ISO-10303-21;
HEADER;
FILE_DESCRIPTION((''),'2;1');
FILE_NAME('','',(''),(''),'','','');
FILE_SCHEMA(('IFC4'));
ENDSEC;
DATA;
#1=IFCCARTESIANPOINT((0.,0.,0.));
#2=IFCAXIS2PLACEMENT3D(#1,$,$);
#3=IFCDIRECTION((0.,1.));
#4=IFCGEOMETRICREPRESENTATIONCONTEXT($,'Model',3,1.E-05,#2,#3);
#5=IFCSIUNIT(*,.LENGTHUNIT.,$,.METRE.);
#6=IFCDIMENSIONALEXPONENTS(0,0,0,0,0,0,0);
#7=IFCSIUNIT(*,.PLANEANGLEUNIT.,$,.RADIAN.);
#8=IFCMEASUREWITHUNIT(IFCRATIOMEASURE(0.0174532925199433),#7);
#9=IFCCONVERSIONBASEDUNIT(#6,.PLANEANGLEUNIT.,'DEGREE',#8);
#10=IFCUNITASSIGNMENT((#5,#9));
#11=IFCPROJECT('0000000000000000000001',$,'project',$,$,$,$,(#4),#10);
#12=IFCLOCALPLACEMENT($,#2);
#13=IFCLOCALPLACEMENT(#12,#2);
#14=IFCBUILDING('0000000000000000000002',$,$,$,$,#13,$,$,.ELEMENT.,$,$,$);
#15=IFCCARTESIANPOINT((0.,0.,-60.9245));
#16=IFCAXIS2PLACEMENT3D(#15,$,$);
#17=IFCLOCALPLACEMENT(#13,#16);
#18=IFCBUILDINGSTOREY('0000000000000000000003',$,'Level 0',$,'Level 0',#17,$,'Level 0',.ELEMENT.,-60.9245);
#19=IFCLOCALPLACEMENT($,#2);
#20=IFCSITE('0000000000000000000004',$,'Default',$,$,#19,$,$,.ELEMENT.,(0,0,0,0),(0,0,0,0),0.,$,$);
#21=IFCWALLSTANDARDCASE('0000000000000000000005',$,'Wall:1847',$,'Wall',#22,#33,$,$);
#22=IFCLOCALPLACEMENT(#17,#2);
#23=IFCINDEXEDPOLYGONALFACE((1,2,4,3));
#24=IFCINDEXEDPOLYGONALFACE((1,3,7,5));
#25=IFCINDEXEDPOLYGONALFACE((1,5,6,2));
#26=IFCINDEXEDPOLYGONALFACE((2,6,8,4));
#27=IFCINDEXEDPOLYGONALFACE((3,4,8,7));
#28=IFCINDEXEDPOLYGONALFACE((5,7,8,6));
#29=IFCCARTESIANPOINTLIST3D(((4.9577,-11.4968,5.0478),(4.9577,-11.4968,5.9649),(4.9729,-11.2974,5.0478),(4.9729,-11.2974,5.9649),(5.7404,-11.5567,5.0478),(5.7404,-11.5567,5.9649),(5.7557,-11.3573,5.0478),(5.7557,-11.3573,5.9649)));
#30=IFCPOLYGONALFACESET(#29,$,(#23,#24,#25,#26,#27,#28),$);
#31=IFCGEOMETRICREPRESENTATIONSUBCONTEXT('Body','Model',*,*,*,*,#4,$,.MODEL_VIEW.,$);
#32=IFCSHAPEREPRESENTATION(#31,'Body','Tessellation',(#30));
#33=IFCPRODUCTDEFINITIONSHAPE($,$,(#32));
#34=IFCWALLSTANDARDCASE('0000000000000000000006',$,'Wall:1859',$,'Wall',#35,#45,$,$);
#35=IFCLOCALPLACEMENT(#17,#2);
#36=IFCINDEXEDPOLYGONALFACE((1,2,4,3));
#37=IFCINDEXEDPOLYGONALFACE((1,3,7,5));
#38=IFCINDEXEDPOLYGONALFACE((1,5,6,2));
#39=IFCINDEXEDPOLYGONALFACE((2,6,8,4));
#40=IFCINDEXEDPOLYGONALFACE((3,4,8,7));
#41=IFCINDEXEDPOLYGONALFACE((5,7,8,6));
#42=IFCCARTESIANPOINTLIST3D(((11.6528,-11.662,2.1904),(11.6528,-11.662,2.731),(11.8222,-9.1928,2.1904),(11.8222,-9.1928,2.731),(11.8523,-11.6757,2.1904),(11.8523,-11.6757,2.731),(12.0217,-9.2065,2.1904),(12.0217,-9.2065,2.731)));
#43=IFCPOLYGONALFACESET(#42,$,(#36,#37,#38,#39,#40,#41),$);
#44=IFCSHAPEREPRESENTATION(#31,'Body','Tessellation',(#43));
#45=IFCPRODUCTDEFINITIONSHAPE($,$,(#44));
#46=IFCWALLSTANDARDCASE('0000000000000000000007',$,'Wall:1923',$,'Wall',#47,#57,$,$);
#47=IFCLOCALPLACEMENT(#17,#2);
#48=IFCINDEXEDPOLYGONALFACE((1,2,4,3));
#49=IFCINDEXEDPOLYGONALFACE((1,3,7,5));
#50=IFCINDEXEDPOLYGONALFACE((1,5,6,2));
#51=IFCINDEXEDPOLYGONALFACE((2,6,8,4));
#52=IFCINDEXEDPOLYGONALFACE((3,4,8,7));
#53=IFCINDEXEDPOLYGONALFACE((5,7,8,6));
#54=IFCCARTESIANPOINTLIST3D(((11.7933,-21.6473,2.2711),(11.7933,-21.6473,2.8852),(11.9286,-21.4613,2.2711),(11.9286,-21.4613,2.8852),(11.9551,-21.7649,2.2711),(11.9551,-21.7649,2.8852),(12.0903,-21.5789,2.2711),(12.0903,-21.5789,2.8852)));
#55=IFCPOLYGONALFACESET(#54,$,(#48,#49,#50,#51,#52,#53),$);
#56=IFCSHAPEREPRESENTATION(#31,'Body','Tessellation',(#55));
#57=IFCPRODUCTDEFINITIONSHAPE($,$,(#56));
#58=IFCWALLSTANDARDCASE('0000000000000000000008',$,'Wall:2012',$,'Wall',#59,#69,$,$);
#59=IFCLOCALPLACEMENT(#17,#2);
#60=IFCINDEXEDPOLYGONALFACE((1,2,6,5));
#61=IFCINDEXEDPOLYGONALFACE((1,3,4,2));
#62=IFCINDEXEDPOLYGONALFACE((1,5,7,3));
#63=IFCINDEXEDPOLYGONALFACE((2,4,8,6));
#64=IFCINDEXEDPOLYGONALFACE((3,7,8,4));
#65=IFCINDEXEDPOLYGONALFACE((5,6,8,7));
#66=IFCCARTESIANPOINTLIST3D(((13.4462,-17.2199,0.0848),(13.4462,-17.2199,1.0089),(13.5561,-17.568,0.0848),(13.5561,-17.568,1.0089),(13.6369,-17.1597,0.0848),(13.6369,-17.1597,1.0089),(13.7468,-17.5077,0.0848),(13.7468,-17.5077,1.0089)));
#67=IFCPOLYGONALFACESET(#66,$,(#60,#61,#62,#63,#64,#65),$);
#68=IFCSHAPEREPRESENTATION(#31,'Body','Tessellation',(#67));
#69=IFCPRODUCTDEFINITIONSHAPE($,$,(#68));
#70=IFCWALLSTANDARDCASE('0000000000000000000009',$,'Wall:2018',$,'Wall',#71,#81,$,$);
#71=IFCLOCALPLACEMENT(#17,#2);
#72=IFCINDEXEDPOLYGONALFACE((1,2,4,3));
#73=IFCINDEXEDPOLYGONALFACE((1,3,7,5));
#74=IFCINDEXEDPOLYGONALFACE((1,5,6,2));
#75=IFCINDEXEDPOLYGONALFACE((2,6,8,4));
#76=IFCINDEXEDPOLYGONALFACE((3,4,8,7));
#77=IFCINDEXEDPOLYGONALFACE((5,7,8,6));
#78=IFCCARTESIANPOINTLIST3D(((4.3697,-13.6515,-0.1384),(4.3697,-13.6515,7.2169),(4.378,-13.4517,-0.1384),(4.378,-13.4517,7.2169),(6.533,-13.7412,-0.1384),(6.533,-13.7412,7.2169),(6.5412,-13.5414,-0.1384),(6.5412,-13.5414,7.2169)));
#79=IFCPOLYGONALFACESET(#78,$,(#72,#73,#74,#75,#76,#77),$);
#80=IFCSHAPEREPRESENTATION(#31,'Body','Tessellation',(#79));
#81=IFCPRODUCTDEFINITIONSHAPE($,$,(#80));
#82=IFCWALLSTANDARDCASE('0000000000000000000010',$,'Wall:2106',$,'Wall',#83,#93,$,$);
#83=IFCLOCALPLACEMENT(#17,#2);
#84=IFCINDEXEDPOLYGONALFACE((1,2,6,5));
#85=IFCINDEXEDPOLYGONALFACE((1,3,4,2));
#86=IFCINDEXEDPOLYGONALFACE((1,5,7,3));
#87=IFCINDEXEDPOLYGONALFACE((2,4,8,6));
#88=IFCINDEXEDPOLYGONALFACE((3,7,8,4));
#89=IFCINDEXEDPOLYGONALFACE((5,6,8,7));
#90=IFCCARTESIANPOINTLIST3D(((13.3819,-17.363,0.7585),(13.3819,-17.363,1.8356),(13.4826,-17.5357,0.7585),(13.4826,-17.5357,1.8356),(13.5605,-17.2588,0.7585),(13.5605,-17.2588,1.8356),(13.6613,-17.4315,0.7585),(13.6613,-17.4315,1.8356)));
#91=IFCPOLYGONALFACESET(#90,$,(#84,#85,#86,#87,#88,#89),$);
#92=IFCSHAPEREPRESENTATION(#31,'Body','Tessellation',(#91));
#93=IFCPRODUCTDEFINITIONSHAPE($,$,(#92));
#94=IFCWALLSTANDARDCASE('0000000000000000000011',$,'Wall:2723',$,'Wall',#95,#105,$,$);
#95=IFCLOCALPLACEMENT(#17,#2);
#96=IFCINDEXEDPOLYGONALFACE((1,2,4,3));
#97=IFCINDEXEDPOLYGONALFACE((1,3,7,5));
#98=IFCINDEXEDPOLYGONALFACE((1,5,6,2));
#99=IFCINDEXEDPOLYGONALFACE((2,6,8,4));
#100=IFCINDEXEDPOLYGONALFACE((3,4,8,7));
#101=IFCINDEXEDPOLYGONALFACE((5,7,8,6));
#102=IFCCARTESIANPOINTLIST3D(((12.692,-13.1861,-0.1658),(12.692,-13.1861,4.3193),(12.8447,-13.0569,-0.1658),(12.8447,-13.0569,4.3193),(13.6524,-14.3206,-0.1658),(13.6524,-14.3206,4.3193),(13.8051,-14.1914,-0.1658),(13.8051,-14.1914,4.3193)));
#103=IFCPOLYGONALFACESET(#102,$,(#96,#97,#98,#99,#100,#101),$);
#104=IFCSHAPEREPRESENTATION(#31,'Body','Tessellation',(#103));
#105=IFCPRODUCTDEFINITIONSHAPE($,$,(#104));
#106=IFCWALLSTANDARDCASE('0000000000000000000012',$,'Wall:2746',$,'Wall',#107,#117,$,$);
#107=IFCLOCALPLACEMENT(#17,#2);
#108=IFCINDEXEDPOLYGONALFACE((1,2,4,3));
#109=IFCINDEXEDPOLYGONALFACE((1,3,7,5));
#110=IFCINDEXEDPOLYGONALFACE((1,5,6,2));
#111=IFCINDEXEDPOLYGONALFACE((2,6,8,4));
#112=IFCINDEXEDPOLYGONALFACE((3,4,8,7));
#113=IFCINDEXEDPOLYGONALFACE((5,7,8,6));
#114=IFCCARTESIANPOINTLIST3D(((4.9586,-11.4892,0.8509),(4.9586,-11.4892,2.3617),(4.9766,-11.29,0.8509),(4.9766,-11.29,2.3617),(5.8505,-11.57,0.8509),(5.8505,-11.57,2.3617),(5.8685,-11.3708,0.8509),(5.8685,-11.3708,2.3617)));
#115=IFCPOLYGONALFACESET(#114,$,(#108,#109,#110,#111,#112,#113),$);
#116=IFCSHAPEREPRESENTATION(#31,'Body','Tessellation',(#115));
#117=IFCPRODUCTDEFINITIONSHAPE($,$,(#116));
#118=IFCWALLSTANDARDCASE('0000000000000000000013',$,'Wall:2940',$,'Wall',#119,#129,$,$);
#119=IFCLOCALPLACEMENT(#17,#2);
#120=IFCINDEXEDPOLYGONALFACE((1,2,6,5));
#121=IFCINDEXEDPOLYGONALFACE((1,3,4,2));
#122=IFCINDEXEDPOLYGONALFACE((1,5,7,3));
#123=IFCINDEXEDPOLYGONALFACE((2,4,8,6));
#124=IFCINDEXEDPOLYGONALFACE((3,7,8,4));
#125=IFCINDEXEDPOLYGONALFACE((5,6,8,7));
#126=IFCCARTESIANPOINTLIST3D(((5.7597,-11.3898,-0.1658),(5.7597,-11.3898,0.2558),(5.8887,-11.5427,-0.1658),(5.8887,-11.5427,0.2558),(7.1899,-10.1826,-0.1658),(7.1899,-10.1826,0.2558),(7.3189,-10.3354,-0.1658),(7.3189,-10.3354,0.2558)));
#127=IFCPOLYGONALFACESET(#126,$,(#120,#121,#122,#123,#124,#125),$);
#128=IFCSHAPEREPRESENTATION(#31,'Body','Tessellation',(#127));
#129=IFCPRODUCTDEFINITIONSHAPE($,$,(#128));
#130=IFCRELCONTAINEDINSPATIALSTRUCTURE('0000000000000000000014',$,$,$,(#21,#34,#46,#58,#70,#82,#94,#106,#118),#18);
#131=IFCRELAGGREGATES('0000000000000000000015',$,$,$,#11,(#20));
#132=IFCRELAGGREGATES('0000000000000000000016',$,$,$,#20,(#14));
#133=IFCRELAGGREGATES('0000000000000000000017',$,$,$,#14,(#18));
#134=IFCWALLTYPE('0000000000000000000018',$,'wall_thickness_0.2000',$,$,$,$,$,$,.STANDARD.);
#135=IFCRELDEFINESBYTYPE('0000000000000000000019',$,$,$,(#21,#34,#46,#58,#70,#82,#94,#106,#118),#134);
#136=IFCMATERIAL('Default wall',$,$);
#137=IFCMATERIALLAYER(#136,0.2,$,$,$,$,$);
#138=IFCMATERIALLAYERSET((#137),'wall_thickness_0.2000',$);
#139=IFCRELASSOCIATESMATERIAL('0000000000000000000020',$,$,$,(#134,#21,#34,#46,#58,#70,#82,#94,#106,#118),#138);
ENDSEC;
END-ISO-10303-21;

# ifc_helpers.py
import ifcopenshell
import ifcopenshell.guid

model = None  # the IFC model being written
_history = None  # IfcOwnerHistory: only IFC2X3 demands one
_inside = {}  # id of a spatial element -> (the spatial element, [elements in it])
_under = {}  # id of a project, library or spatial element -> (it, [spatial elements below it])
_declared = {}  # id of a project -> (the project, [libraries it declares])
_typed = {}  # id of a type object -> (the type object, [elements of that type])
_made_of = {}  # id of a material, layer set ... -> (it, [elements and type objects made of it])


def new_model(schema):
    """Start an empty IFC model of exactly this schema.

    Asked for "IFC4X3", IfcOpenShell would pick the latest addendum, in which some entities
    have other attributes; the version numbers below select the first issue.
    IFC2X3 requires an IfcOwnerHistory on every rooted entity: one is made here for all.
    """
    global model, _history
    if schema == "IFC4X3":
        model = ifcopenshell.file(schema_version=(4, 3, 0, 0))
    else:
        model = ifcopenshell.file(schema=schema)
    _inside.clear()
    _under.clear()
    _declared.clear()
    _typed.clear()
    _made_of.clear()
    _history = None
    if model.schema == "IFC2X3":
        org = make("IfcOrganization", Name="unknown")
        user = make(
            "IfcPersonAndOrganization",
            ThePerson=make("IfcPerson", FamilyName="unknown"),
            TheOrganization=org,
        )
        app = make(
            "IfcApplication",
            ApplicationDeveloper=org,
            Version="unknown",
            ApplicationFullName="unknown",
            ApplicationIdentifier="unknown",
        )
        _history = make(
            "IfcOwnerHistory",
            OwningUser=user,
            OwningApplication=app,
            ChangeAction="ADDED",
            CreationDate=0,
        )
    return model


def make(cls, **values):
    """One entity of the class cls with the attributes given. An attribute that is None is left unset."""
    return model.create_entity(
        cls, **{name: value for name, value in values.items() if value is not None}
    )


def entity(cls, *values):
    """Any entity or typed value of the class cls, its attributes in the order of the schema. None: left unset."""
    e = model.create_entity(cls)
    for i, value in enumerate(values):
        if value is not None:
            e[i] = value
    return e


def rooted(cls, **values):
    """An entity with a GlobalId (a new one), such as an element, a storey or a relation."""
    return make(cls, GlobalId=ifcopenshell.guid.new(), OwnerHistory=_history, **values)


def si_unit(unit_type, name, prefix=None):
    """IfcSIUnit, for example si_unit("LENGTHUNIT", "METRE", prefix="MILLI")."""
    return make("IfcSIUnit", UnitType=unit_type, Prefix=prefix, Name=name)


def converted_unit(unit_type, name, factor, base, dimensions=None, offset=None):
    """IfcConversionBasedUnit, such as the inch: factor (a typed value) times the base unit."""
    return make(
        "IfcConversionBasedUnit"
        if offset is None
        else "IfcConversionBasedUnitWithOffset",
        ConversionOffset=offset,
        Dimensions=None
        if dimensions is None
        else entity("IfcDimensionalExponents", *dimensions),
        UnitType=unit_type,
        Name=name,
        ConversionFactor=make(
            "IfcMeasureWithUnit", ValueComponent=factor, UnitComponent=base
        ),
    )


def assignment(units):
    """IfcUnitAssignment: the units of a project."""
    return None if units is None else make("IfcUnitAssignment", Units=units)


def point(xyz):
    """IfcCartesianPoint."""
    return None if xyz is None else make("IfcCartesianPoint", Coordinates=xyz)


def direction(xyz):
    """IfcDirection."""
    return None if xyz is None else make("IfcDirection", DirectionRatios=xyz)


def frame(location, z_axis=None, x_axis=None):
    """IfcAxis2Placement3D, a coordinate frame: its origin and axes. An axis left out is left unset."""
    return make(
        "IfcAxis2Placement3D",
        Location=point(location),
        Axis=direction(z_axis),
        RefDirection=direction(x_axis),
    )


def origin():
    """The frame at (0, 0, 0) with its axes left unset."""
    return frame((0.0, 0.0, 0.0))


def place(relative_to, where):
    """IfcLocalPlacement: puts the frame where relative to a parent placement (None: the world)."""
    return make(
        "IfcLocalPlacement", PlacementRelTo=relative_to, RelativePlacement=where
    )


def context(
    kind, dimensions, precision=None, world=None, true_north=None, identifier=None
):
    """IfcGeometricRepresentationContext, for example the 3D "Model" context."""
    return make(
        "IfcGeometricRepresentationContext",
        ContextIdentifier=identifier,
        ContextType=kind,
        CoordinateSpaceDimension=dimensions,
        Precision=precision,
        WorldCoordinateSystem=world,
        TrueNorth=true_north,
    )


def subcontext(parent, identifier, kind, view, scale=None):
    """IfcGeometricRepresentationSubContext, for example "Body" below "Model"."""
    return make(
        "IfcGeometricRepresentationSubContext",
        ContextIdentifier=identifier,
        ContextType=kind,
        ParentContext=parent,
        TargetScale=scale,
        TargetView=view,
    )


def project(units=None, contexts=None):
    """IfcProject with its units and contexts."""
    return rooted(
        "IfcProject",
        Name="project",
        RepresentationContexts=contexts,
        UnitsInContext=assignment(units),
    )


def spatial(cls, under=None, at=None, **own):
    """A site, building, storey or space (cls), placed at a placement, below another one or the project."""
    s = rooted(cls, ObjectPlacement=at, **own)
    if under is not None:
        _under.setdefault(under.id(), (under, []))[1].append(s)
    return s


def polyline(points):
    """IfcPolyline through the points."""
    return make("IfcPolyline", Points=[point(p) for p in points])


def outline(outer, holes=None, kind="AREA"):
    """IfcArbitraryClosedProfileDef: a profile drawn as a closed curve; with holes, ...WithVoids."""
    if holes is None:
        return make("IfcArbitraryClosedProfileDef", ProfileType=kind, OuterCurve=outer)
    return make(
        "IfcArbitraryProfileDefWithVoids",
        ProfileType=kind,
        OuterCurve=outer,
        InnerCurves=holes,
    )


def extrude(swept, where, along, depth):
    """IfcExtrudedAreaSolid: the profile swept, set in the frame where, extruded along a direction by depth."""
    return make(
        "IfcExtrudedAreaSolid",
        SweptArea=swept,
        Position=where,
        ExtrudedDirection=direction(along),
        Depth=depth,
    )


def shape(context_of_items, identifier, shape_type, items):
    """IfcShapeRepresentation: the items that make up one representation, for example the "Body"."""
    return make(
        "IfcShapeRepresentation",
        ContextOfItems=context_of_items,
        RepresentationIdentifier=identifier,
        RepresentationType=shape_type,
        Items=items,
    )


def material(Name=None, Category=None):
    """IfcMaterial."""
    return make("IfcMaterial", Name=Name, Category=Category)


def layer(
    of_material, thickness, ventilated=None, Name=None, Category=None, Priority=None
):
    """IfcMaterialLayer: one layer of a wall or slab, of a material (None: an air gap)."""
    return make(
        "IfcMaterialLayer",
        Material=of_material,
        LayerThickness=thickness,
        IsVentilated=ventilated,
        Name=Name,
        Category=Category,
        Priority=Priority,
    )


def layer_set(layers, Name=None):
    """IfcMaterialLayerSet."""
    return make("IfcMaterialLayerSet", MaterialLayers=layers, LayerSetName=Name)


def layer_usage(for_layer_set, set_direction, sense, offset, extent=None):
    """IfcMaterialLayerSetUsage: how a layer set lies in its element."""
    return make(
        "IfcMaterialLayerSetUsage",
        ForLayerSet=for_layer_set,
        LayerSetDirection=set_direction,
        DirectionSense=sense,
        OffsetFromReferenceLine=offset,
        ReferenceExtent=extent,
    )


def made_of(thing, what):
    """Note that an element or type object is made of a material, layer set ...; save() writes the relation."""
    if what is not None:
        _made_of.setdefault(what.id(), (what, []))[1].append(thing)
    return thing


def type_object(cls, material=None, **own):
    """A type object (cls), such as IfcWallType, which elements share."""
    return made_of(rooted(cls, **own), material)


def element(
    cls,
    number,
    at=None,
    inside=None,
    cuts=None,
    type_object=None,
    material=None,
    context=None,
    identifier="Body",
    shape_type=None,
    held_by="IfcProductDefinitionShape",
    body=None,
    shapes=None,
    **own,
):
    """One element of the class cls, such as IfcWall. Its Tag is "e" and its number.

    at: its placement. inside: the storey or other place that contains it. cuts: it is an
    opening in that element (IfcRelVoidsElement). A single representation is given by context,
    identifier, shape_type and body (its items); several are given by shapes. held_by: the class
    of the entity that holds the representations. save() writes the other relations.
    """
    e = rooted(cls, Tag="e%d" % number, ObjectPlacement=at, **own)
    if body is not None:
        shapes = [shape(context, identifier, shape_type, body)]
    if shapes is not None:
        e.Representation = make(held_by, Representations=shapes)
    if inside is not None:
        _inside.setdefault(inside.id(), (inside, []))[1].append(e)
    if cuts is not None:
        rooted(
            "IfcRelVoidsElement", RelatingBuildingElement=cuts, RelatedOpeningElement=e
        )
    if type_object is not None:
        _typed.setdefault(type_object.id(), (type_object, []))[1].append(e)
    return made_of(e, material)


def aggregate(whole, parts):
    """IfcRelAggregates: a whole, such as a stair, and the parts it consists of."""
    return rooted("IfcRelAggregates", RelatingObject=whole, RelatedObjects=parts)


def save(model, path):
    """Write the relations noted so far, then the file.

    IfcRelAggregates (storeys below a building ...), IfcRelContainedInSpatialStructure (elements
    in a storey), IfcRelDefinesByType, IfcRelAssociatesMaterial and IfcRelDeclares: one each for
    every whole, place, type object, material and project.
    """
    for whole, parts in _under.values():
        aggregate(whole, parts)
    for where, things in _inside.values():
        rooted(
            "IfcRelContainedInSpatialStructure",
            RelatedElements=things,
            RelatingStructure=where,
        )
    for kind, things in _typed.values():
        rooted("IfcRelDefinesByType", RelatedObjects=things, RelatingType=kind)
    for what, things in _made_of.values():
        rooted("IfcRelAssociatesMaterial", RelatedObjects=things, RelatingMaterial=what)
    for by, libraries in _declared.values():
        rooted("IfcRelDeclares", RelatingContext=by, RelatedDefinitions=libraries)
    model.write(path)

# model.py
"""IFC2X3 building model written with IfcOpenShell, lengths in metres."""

from ifc_helpers import new_model, entity, si_unit, converted_unit, direction, frame, origin, place, context, subcontext, project, spatial, polyline, outline, extrude, material, layer, layer_set, layer_usage, type_object, element, save


model = new_model("IFC2X3")

# Units and contexts
model_context = context("Model", 3, precision=1e-05, world=origin(), true_north=direction((0.0, 1.0)))
body_context = subcontext(model_context, "Body", "Model", "MODEL_VIEW")
ifc_project = project(units=[si_unit("LENGTHUNIT", "METRE"), converted_unit("PLANEANGLEUNIT", "DEGREE", entity("IfcRatioMeasure", 0.0174532925199433), si_unit("PLANEANGLEUNIT", "RADIAN"), dimensions=[0, 0, 0, 0, 0, 0, 0])], contexts=[model_context])

# Site, building, storey
site_placement = place(None, origin())
site = spatial("IfcSite", under=ifc_project, at=site_placement, Name="Default", CompositionType="ELEMENT", RefLatitude=(0, 0, 0, 0), RefLongitude=(0, 0, 0, 0), RefElevation=0.0)
placement_1 = place(None, origin())
building_placement = place(placement_1, origin())
building = spatial("IfcBuilding", under=site, at=building_placement, CompositionType="ELEMENT")
storey_placement = place(building_placement, frame((0.0, 0.0, -60.9245)))
storey = spatial("IfcBuildingStorey", under=building, at=storey_placement, Name="Level 0", ObjectType="Level 0", LongName="Level 0", CompositionType="ELEMENT", Elevation=-60.9245)

# Shared definitions
ifc_material_1 = material(Name="Default wall")
ifc_layer = layer(ifc_material_1, 0.2)
ifc_layer_set = layer_set([ifc_layer], Name="wall_thickness_0.2000")
ifc_layer_usage = layer_usage(ifc_layer_set, "AXIS2", "POSITIVE", -0.1)
wall_type = type_object("IfcWallType", Name="wall_thickness_0.2000", PredefinedType="STANDARD", material=ifc_layer_set)

# Walls
placement_2 = place(building_placement, frame((0.0, 0.0, -55.8767)))
wall_1_placement = place(placement_2, frame((5.748, -11.457, 0.0), z_axis=(0.0, 0.0, 1.0), x_axis=(-0.997084, 0.076317, 0.0)))
element("IfcWallStandardCase", 1, at=wall_1_placement, inside=storey, type_object=wall_type, material=ifc_layer_usage, Name="Wall:1847", ObjectType="Wall", context=body_context, shape_type="SweptSolid", body=[
    extrude(outline(polyline([(0.785, -0.1), (0.785, 0.1), (0.0, 0.1), (0.0, -0.1), (0.785, -0.1)])), origin(), (0.0, 0.0, 1.0), 0.9171),
])
placement_3 = place(building_placement, frame((0.0, 0.0, -58.7341)))
wall_2_placement = place(placement_3, frame((11.7525, -11.6688, 0.0), z_axis=(0.0, 0.0, 1.0), x_axis=(0.068442, 0.997655, 0.0)))
element("IfcWallStandardCase", 2, at=wall_2_placement, inside=storey, type_object=wall_type, material=ifc_layer_usage, Name="Wall:1859", ObjectType="Wall", context=body_context, shape_type="SweptSolid", body=[
    extrude(outline(polyline([(2.475, -0.1), (2.475, 0.1), (0.0, 0.1), (0.0, -0.1), (2.475, -0.1)])), origin(), (0.0, 0.0, 1.0), 0.5407),
])
placement_4 = place(building_placement, frame((0.0, 0.0, -58.6534)))
wall_3_placement = place(placement_4, frame((12.0095, -21.5201, 0.0), z_axis=(0.0, 0.0, 1.0), x_axis=(-0.588006, -0.808856, 0.0)))
element("IfcWallStandardCase", 3, at=wall_3_placement, inside=storey, type_object=wall_type, material=ifc_layer_usage, Name="Wall:1923", ObjectType="Wall", context=body_context, shape_type="SweptSolid", body=[
    extrude(outline(polyline([(0.23, -0.1), (0.23, 0.1), (0.0, 0.1), (0.0, -0.1), (0.23, -0.1)])), origin(), (0.0, 0.0, 1.0), 0.6141),
])
placement_5 = place(building_placement, frame((0.0, 0.0, -60.8397)))
wall_4_placement = place(placement_5, frame((13.6514, -17.5378, 0.0), z_axis=(0.0, 0.0, 1.0), x_axis=(-0.301101, 0.953592, 0.0)))
element("IfcWallStandardCase", 4, at=wall_4_placement, inside=storey, type_object=wall_type, material=ifc_layer_usage, Name="Wall:2012", ObjectType="Wall", context=body_context, shape_type="SweptSolid", body=[
    extrude(outline(polyline([(0.365, -0.1), (0.365, 0.1), (0.0, 0.1), (0.0, -0.1), (0.365, -0.1)])), origin(), (0.0, 0.0, 1.0), 0.9242),
])
placement_6 = place(building_placement, frame((0.0, 0.0, -61.0629)))
wall_5_placement = place(placement_6, frame((6.5371, -13.6413, 0.0), z_axis=(0.0, 0.0, 1.0), x_axis=(-0.999142, 0.041423, 0.0)))
element("IfcWallStandardCase", 5, at=wall_5_placement, inside=storey, type_object=wall_type, material=ifc_layer_usage, Name="Wall:2018", ObjectType="Wall", context=body_context, shape_type="SweptSolid", body=[
    extrude(outline(polyline([(2.1651, -0.1), (2.1651, 0.1), (0.0, 0.1), (0.0, -0.1), (2.1651, -0.1)])), origin(), (0.0, 0.0, 1.0), 7.3553),
])
placement_7 = place(building_placement, frame((0.0, 0.0, -60.166)))
wall_6_placement = place(placement_7, frame((13.6109, -17.3451, 0.0), z_axis=(0.0, 0.0, 1.0), x_axis=(-0.863775, -0.503878, 0.0)))
element("IfcWallStandardCase", 6, at=wall_6_placement, inside=storey, type_object=wall_type, material=ifc_layer_usage, Name="Wall:2106", ObjectType="Wall", context=body_context, shape_type="SweptSolid", body=[
    extrude(outline(polyline([(0.2068, -0.1), (0.2068, 0.1), (0.0, 0.1), (0.0, -0.1), (0.2068, -0.1)])), origin(), (0.0, 0.0, 1.0), 1.0771),
])
placement_8 = place(building_placement, frame((0.0, 0.0, -61.0903)))
wall_7_placement = place(placement_8, frame((13.7287, -14.256, 0.0), z_axis=(0.0, 0.0, 1.0), x_axis=(-0.646115, 0.76324, 0.0)))
element("IfcWallStandardCase", 7, at=wall_7_placement, inside=storey, type_object=wall_type, material=ifc_layer_usage, Name="Wall:2723", ObjectType="Wall", context=body_context, shape_type="SweptSolid", body=[
    extrude(outline(polyline([(1.4864, -0.1), (1.4864, 0.1), (0.0, 0.1), (0.0, -0.1), (1.4864, -0.1)])), origin(), (0.0, 0.0, 1.0), 4.4851),
])
placement_9 = place(building_placement, frame((0.0, 0.0, -60.0736)))
wall_8_placement = place(placement_9, frame((4.9676, -11.3896, 0.0), z_axis=(0.0, 0.0, 1.0), x_axis=(0.995925, -0.090187, 0.0)))
element("IfcWallStandardCase", 8, at=wall_8_placement, inside=storey, type_object=wall_type, material=ifc_layer_usage, Name="Wall:2746", ObjectType="Wall", context=body_context, shape_type="SweptSolid", body=[
    extrude(outline(polyline([(0.8956, -0.1), (0.8956, 0.1), (0.0, 0.1), (0.0, -0.1), (0.8956, -0.1)])), origin(), (0.0, 0.0, 1.0), 1.5109),
])
placement_10 = place(building_placement, frame((0.0, 0.0, -61.0903)))
wall_9_placement = place(placement_10, frame((5.8242, -11.4663, 0.0), z_axis=(0.0, 0.0, 1.0), x_axis=(0.764167, 0.645019, 0.0)))
element("IfcWallStandardCase", 9, at=wall_9_placement, inside=storey, type_object=wall_type, material=ifc_layer_usage, Name="Wall:2940", ObjectType="Wall", context=body_context, shape_type="SweptSolid", body=[
    extrude(outline(polyline([(1.8716, -0.1), (1.8716, 0.1), (0.0, 0.1), (0.0, -0.1), (1.8716, -0.1)])), origin(), (0.0, 0.0, 1.0), 0.4216),
])

save(model, "model.ifc")
